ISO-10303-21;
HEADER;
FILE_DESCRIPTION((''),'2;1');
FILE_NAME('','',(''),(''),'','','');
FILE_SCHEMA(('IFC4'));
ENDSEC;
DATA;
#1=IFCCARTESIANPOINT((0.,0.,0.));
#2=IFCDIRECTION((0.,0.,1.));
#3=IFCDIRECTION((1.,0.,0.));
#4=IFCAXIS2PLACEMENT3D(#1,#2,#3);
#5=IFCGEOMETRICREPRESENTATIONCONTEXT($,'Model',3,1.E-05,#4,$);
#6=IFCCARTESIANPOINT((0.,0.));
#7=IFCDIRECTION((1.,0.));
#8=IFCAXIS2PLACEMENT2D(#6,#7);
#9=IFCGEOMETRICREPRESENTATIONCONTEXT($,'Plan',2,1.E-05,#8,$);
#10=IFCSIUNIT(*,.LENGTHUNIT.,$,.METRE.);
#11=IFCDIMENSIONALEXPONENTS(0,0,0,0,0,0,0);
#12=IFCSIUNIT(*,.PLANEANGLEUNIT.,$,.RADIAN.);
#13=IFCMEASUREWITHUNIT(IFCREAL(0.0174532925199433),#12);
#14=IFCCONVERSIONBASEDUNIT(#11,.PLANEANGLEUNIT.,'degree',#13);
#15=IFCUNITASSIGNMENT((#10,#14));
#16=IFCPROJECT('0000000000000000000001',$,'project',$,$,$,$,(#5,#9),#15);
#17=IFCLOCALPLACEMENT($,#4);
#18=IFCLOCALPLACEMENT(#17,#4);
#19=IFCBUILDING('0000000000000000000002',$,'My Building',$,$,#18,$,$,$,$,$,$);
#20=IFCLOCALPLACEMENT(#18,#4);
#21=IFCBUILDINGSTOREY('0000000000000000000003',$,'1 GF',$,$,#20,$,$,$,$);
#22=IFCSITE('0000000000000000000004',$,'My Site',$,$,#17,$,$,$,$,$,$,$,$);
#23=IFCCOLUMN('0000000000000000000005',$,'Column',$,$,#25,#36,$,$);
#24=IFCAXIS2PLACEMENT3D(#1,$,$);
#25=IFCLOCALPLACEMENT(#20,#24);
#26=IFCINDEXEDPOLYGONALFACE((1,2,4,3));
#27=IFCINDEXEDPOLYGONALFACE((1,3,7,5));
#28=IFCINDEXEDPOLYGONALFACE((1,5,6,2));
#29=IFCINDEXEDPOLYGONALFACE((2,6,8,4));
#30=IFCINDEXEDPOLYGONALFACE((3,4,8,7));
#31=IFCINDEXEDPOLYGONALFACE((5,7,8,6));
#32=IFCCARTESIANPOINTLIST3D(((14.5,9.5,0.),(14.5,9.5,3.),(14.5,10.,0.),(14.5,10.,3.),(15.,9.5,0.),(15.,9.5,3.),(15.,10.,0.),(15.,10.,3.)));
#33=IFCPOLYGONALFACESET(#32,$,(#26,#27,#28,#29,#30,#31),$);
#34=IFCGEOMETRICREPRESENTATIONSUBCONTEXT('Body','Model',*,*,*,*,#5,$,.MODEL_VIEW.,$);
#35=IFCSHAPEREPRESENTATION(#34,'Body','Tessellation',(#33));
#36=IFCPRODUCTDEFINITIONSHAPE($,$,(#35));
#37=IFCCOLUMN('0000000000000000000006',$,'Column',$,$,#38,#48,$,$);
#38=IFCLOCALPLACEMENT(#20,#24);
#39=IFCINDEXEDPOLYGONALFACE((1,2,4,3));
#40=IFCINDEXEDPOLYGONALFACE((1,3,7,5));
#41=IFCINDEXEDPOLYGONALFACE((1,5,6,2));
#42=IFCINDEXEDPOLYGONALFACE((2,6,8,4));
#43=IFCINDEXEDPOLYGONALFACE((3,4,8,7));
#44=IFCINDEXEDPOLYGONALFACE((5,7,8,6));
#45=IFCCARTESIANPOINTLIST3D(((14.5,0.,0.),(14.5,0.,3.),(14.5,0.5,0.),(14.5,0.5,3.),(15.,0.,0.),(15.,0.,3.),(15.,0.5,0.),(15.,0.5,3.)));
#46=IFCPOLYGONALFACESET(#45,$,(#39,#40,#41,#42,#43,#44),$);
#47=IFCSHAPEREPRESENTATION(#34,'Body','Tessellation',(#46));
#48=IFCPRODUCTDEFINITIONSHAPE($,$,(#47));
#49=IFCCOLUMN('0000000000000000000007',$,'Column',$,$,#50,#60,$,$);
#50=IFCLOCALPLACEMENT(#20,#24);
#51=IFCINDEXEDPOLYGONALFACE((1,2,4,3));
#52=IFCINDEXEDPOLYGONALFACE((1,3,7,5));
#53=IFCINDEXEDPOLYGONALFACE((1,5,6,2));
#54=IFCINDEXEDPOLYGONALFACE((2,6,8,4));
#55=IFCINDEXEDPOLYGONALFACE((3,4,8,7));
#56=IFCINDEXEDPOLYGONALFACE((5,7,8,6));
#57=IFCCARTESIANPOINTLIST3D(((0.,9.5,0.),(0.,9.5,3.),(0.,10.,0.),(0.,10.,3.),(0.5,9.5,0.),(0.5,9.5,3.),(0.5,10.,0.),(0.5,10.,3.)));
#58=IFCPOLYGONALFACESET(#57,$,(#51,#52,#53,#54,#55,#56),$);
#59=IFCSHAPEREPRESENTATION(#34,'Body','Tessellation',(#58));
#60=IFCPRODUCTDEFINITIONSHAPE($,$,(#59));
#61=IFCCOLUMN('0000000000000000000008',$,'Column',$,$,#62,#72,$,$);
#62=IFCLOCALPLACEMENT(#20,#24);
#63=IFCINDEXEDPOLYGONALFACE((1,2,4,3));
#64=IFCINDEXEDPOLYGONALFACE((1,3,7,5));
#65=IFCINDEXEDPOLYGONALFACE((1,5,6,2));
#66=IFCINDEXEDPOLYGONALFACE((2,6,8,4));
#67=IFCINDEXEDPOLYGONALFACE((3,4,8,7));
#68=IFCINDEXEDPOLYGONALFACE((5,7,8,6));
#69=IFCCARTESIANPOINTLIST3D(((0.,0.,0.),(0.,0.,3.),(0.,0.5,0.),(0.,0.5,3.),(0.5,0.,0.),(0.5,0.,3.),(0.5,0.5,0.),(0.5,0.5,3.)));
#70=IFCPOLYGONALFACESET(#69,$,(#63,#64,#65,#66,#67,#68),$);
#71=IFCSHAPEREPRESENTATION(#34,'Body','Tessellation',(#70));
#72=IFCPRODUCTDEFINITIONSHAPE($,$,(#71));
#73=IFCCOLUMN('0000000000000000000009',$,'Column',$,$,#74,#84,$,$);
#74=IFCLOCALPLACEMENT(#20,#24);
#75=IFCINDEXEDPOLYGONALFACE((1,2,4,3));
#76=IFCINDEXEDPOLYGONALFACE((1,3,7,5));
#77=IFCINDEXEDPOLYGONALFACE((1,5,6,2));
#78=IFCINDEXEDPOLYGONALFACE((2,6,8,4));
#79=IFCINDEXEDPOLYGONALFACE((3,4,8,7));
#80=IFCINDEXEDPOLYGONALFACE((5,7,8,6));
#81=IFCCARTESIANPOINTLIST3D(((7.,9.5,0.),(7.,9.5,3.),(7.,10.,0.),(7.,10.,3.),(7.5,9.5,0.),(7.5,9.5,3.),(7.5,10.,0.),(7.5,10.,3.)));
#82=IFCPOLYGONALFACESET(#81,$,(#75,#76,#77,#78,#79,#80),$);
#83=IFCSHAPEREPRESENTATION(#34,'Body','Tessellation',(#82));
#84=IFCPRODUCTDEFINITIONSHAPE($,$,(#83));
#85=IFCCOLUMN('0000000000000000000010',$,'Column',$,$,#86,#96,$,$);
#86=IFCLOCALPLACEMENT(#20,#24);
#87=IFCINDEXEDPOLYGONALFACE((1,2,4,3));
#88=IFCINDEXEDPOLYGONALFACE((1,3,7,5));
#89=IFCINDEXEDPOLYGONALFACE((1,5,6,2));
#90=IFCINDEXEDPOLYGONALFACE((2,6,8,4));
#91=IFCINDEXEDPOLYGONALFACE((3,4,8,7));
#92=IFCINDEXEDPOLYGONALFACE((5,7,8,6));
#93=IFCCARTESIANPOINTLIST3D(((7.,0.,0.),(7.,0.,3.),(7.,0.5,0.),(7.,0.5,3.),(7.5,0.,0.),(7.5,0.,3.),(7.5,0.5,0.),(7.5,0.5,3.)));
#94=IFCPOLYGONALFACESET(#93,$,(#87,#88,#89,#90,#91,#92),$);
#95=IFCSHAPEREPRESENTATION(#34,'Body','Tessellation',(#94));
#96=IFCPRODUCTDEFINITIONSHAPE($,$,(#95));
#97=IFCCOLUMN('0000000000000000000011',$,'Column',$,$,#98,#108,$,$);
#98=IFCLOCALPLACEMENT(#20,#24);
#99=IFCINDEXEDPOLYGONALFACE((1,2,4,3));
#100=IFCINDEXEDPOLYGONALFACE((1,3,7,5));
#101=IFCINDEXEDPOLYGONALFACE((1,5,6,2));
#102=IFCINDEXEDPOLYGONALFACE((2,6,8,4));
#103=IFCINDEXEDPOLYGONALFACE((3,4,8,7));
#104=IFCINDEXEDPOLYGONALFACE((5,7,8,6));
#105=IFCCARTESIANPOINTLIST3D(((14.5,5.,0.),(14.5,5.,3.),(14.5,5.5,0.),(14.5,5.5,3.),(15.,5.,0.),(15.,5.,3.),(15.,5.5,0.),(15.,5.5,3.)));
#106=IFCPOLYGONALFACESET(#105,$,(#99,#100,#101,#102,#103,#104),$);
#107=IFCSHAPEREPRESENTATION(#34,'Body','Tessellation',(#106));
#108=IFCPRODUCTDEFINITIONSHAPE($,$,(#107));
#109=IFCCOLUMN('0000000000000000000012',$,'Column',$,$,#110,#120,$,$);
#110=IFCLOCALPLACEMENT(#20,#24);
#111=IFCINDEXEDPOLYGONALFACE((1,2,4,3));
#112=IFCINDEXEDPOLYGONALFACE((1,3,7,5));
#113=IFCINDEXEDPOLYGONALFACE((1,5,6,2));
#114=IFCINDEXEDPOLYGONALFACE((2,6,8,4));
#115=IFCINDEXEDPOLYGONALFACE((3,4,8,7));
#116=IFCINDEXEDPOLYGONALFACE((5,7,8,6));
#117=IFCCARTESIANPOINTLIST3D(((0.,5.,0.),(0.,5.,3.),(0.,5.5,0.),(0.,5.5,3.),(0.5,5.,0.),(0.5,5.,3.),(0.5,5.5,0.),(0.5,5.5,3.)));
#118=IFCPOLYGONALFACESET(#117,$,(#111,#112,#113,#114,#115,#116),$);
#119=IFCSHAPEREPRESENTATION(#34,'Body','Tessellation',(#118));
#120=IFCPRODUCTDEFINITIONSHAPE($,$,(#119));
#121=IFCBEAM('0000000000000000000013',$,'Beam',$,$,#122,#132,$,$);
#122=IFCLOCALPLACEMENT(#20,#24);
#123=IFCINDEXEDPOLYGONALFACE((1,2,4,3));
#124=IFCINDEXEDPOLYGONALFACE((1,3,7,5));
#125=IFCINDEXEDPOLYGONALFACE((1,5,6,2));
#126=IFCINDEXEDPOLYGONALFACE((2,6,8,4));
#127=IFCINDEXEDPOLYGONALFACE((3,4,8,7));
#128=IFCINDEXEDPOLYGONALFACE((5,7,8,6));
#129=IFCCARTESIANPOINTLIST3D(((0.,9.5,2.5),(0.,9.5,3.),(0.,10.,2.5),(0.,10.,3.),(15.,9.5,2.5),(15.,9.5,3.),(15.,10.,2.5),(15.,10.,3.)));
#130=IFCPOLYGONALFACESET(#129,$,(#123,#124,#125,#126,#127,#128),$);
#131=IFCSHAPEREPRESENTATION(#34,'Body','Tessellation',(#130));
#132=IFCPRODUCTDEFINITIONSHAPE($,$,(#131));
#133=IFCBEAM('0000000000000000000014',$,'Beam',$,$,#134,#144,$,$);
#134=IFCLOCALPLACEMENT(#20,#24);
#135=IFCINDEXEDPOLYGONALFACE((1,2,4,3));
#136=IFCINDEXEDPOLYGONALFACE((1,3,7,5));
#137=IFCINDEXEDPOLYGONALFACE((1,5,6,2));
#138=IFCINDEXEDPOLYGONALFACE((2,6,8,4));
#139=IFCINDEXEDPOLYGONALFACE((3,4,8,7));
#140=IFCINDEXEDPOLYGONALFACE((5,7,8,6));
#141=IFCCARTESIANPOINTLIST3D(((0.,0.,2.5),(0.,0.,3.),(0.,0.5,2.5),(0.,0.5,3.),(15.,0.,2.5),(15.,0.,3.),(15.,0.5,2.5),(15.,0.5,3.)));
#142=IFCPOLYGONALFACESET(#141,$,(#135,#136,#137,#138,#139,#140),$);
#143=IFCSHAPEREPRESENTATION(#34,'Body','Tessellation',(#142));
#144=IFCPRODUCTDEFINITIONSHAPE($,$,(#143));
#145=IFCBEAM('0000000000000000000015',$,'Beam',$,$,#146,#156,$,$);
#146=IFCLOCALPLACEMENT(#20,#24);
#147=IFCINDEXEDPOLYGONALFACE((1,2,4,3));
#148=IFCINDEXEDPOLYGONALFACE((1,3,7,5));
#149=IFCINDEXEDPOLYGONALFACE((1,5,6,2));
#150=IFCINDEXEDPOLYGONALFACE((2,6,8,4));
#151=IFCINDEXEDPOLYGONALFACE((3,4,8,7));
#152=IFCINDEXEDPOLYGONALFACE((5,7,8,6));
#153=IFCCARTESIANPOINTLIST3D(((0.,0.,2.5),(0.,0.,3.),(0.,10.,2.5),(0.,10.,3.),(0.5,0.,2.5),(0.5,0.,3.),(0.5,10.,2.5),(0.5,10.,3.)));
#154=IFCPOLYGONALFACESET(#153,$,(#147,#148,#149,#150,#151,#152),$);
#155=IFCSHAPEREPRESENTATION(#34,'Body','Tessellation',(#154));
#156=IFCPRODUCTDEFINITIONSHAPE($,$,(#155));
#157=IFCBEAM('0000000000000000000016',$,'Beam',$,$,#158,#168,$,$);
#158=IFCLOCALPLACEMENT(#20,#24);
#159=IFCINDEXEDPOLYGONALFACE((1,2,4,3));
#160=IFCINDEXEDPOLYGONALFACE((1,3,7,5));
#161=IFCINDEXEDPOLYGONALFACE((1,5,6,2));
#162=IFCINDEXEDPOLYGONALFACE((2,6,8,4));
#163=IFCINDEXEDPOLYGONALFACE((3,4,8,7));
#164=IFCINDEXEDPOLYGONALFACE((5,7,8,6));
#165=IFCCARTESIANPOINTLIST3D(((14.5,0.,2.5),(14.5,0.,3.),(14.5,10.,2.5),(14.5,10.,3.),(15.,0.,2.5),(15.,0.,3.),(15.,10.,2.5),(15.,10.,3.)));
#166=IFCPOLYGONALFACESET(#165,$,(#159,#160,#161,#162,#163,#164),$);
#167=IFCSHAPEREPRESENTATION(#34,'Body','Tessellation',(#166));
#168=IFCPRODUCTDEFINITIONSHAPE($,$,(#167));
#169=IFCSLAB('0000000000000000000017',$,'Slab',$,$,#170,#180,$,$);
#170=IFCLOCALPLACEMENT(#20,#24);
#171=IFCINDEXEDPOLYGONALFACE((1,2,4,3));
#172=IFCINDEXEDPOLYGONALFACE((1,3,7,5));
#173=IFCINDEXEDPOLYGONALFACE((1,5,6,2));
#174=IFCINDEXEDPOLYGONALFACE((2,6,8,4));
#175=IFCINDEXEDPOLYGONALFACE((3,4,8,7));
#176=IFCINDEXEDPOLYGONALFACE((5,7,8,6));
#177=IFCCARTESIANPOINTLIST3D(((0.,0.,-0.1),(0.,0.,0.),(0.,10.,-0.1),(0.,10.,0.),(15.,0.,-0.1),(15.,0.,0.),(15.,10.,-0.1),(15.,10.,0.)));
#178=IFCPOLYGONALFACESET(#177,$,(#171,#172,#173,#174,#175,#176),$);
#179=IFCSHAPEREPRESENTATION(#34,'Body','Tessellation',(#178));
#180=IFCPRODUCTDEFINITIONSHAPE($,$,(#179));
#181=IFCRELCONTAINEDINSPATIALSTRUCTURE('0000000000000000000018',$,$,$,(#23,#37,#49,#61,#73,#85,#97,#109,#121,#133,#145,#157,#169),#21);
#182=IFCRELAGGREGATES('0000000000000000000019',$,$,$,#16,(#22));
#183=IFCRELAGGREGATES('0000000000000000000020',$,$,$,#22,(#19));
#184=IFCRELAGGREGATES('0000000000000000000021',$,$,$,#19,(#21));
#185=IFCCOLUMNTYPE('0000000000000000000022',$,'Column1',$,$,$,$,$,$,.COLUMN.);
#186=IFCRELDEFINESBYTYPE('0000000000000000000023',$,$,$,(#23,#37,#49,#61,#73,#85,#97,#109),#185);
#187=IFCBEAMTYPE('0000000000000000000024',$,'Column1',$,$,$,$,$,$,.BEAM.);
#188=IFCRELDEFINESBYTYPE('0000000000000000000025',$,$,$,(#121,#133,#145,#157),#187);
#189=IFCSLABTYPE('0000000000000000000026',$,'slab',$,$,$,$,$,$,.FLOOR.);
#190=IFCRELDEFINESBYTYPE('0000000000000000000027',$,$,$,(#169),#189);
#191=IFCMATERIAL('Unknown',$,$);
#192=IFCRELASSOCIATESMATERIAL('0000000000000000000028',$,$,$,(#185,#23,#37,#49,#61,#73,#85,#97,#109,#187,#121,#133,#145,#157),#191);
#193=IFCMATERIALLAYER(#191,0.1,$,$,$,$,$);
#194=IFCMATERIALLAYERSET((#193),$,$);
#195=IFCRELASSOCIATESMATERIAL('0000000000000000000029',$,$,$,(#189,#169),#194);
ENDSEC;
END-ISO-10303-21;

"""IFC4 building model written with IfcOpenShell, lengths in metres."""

from ifc_helpers import new_model, entity, si_unit, converted_unit, frame, origin_with_axes, origin_2d_with_axis, place, context, subcontext, project, spatial, indexed_curve, rectangle, outline, extrude, material, layer, layer_set, layer_usage, material_profile, profile_set, profile_usage, type_object, element, save


model = new_model("IFC4")

# Units and contexts
model_context = context("Model", 3, precision=1e-05, world=origin_with_axes())
plan_context = context("Plan", 2, precision=1e-05, world=origin_2d_with_axis())
body_context_1 = subcontext(model_context, "Body", "Model", "MODEL_VIEW")
ifc_project = project(units=[si_unit("LENGTHUNIT", "METRE"), converted_unit("PLANEANGLEUNIT", "degree", entity("IfcReal", 0.0174532925199433), si_unit("PLANEANGLEUNIT", "RADIAN"), dimensions=[0, 0, 0, 0, 0, 0, 0])], contexts=[model_context, plan_context])

# Site, building, storey
site_placement = place(None, origin_with_axes())
site = spatial("IfcSite", under=ifc_project, at=site_placement, Name="My Site")
building_placement = place(site_placement, origin_with_axes())
building = spatial("IfcBuilding", under=site, at=building_placement, Name="My Building")
storey_placement = place(building_placement, origin_with_axes())
storey = spatial("IfcBuildingStorey", under=building, at=storey_placement, Name="1 GF")

# Columns
ifc_material = material(Name="Unknown")
ifc_material_profile_1 = material_profile(ifc_material, rectangle(XDim=0.5, YDim=0.5))
ifc_profile_set_1 = profile_set([ifc_material_profile_1])
ifc_profile_usage_1 = profile_usage(ifc_profile_set_1, cardinal=1)
column_type = type_object("IfcColumnType", Name="Column1", PredefinedType="COLUMN", material=ifc_profile_set_1)
column_1_placement = place(storey_placement, frame((15.0, 9.5, 0.0), z_axis=(0.0, 0.0, 1.0), x_axis=(1.0, 0.0, 0.0)))
element("IfcColumn", 1, at=column_1_placement, inside=storey, type_object=column_type, material=ifc_profile_usage_1, Name="Column", context=body_context_1, shape_type="SweptSolid", body=[
    extrude(rectangle(XDim=0.5, YDim=0.5), frame((-0.25, 0.25, 0.0), z_axis=(0.0, 0.0, 1.0), x_axis=(1.0, 0.0, 0.0)), (0.0, 0.0, 1.0), 3.0),
])
ifc_profile_usage_2 = profile_usage(ifc_profile_set_1, cardinal=1)
column_2_placement = place(storey_placement, frame((15.0, 0.0, 0.0), z_axis=(0.0, 0.0, 1.0), x_axis=(1.0, 0.0, 0.0)))
element("IfcColumn", 2, at=column_2_placement, inside=storey, type_object=column_type, material=ifc_profile_usage_2, Name="Column", context=body_context_1, shape_type="SweptSolid", body=[
    extrude(rectangle(XDim=0.5, YDim=0.5), frame((-0.25, 0.25, 0.0), z_axis=(0.0, 0.0, 1.0), x_axis=(1.0, 0.0, 0.0)), (0.0, 0.0, 1.0), 3.0),
])
ifc_profile_usage_3 = profile_usage(ifc_profile_set_1, cardinal=1)
column_3_placement = place(storey_placement, frame((0.5, 9.5, 0.0), z_axis=(0.0, 0.0, 1.0), x_axis=(1.0, 0.0, 0.0)))
element("IfcColumn", 3, at=column_3_placement, inside=storey, type_object=column_type, material=ifc_profile_usage_3, Name="Column", context=body_context_1, shape_type="SweptSolid", body=[
    extrude(rectangle(XDim=0.5, YDim=0.5), frame((-0.25, 0.25, 0.0), z_axis=(0.0, 0.0, 1.0), x_axis=(1.0, 0.0, 0.0)), (0.0, 0.0, 1.0), 3.0),
])
ifc_profile_usage_4 = profile_usage(ifc_profile_set_1, cardinal=1)
column_4_placement = place(storey_placement, frame((0.5, 0.0, 0.0), z_axis=(0.0, 0.0, 1.0), x_axis=(1.0, 0.0, 0.0)))
element("IfcColumn", 4, at=column_4_placement, inside=storey, type_object=column_type, material=ifc_profile_usage_4, Name="Column", context=body_context_1, shape_type="SweptSolid", body=[
    extrude(rectangle(XDim=0.5, YDim=0.5), frame((-0.25, 0.25, 0.0), z_axis=(0.0, 0.0, 1.0), x_axis=(1.0, 0.0, 0.0)), (0.0, 0.0, 1.0), 3.0),
])
ifc_profile_usage_5 = profile_usage(ifc_profile_set_1, cardinal=1)
column_5_placement = place(storey_placement, frame((7.5, 9.5, 0.0), z_axis=(0.0, 0.0, 1.0), x_axis=(1.0, 0.0, 0.0)))
element("IfcColumn", 5, at=column_5_placement, inside=storey, type_object=column_type, material=ifc_profile_usage_5, Name="Column", context=body_context_1, shape_type="SweptSolid", body=[
    extrude(rectangle(XDim=0.5, YDim=0.5), frame((-0.25, 0.25, 0.0), z_axis=(0.0, 0.0, 1.0), x_axis=(1.0, 0.0, 0.0)), (0.0, 0.0, 1.0), 3.0),
])
ifc_profile_usage_6 = profile_usage(ifc_profile_set_1, cardinal=1)
column_6_placement = place(storey_placement, frame((7.5, 0.0, 0.0), z_axis=(0.0, 0.0, 1.0), x_axis=(1.0, 0.0, 0.0)))
element("IfcColumn", 6, at=column_6_placement, inside=storey, type_object=column_type, material=ifc_profile_usage_6, Name="Column", context=body_context_1, shape_type="SweptSolid", body=[
    extrude(rectangle(XDim=0.5, YDim=0.5), frame((-0.25, 0.25, 0.0), z_axis=(0.0, 0.0, 1.0), x_axis=(1.0, 0.0, 0.0)), (0.0, 0.0, 1.0), 3.0),
])
ifc_profile_usage_7 = profile_usage(ifc_profile_set_1, cardinal=1)
column_7_placement = place(storey_placement, frame((15.0, 5.0, 0.0), z_axis=(0.0, 0.0, 1.0), x_axis=(1.0, 0.0, 0.0)))
element("IfcColumn", 7, at=column_7_placement, inside=storey, type_object=column_type, material=ifc_profile_usage_7, Name="Column", context=body_context_1, shape_type="SweptSolid", body=[
    extrude(rectangle(XDim=0.5, YDim=0.5), frame((-0.25, 0.25, 0.0), z_axis=(0.0, 0.0, 1.0), x_axis=(1.0, 0.0, 0.0)), (0.0, 0.0, 1.0), 3.0),
])
ifc_profile_usage_8 = profile_usage(ifc_profile_set_1, cardinal=1)
column_8_placement = place(storey_placement, frame((0.5, 5.0, 0.0), z_axis=(0.0, 0.0, 1.0), x_axis=(1.0, 0.0, 0.0)))
element("IfcColumn", 8, at=column_8_placement, inside=storey, type_object=column_type, material=ifc_profile_usage_8, Name="Column", context=body_context_1, shape_type="SweptSolid", body=[
    extrude(rectangle(XDim=0.5, YDim=0.5), frame((-0.25, 0.25, 0.0), z_axis=(0.0, 0.0, 1.0), x_axis=(1.0, 0.0, 0.0)), (0.0, 0.0, 1.0), 3.0),
])

# Beams
ifc_material_profile_2 = material_profile(ifc_material, rectangle(XDim=0.5, YDim=0.5))
ifc_profile_set_2 = profile_set([ifc_material_profile_2])
ifc_profile_usage_9 = profile_usage(ifc_profile_set_2, cardinal=7)
beam_type = type_object("IfcBeamType", Name="Column1", PredefinedType="BEAM", material=ifc_profile_set_2)
beam_1_placement = place(storey_placement, frame((0.0, 10.0, 3.0), z_axis=(1.0, 0.0, 0.0), x_axis=(0.0, 1.0, 0.0)))
element("IfcBeam", 9, at=beam_1_placement, inside=storey, type_object=beam_type, material=ifc_profile_usage_9, Name="Beam", context=body_context_1, shape_type="SweptSolid", body=[
    extrude(rectangle(XDim=0.5, YDim=0.5), frame((-0.25, -0.25, 0.0), z_axis=(0.0, 0.0, 1.0), x_axis=(1.0, 0.0, 0.0)), (0.0, 0.0, 1.0), 15.0),
])
ifc_profile_usage_10 = profile_usage(ifc_profile_set_2, cardinal=7)
beam_2_placement = place(storey_placement, frame((0.0, 0.5, 3.0), z_axis=(1.0, 0.0, 0.0), x_axis=(0.0, 1.0, 0.0)))
element("IfcBeam", 10, at=beam_2_placement, inside=storey, type_object=beam_type, material=ifc_profile_usage_10, Name="Beam", context=body_context_1, shape_type="SweptSolid", body=[
    extrude(rectangle(XDim=0.5, YDim=0.5), frame((-0.25, -0.25, 0.0), z_axis=(0.0, 0.0, 1.0), x_axis=(1.0, 0.0, 0.0)), (0.0, 0.0, 1.0), 15.0),
])
ifc_profile_usage_11 = profile_usage(ifc_profile_set_2, cardinal=7)
beam_3_placement = place(storey_placement, frame((0.5, 10.0, 3.0), z_axis=(0.0, -1.0, 0.0), x_axis=(1.0, 0.0, 0.0)))
element("IfcBeam", 11, at=beam_3_placement, inside=storey, type_object=beam_type, material=ifc_profile_usage_11, Name="Beam", context=body_context_1, shape_type="SweptSolid", body=[
    extrude(rectangle(XDim=0.5, YDim=0.5), frame((-0.25, -0.25, 0.0), z_axis=(0.0, 0.0, 1.0), x_axis=(1.0, 0.0, 0.0)), (0.0, 0.0, 1.0), 10.0),
])
ifc_profile_usage_12 = profile_usage(ifc_profile_set_2, cardinal=7)
beam_4_placement = place(storey_placement, frame((15.0, 10.0, 3.0), z_axis=(0.0, -1.0, 0.0), x_axis=(1.0, 0.0, 0.0)))
element("IfcBeam", 12, at=beam_4_placement, inside=storey, type_object=beam_type, material=ifc_profile_usage_12, Name="Beam", context=body_context_1, shape_type="SweptSolid", body=[
    extrude(rectangle(XDim=0.5, YDim=0.5), frame((-0.25, -0.25, 0.0), z_axis=(0.0, 0.0, 1.0), x_axis=(1.0, 0.0, 0.0)), (0.0, 0.0, 1.0), 10.0),
])

# Slab
ifc_layer_1 = layer(ifc_material, 0.1)
ifc_layer_set_1 = layer_set([ifc_layer_1])
ifc_layer_usage_1 = layer_usage(ifc_layer_set_1, "AXIS3", "POSITIVE", -0.1)
slab_type = type_object("IfcSlabType", Name="slab", PredefinedType="FLOOR", material=ifc_layer_set_1)
slab_placement = place(storey_placement, frame((0.0, 10.0, 0.0), z_axis=(0.0, 0.0, 1.0), x_axis=(1.0, 0.0, 0.0)))
element("IfcSlab", 13, at=slab_placement, inside=storey, type_object=slab_type, material=ifc_layer_usage_1, Name="Slab", context=body_context_1, shape_type="SweptSolid", body=[
    extrude(outline(indexed_curve([(0.0, 0.0), (0.0, -10.0), (15.0, -10.0), (15.0, 0.0), (0.0, 0.0)])), frame((0.0, 0.0, -0.1), z_axis=(0.0, 0.0, 1.0), x_axis=(1.0, 0.0, 0.0)), (0.0, 0.0, 1.0), 0.1),
])

save(model, "model.ifc")
